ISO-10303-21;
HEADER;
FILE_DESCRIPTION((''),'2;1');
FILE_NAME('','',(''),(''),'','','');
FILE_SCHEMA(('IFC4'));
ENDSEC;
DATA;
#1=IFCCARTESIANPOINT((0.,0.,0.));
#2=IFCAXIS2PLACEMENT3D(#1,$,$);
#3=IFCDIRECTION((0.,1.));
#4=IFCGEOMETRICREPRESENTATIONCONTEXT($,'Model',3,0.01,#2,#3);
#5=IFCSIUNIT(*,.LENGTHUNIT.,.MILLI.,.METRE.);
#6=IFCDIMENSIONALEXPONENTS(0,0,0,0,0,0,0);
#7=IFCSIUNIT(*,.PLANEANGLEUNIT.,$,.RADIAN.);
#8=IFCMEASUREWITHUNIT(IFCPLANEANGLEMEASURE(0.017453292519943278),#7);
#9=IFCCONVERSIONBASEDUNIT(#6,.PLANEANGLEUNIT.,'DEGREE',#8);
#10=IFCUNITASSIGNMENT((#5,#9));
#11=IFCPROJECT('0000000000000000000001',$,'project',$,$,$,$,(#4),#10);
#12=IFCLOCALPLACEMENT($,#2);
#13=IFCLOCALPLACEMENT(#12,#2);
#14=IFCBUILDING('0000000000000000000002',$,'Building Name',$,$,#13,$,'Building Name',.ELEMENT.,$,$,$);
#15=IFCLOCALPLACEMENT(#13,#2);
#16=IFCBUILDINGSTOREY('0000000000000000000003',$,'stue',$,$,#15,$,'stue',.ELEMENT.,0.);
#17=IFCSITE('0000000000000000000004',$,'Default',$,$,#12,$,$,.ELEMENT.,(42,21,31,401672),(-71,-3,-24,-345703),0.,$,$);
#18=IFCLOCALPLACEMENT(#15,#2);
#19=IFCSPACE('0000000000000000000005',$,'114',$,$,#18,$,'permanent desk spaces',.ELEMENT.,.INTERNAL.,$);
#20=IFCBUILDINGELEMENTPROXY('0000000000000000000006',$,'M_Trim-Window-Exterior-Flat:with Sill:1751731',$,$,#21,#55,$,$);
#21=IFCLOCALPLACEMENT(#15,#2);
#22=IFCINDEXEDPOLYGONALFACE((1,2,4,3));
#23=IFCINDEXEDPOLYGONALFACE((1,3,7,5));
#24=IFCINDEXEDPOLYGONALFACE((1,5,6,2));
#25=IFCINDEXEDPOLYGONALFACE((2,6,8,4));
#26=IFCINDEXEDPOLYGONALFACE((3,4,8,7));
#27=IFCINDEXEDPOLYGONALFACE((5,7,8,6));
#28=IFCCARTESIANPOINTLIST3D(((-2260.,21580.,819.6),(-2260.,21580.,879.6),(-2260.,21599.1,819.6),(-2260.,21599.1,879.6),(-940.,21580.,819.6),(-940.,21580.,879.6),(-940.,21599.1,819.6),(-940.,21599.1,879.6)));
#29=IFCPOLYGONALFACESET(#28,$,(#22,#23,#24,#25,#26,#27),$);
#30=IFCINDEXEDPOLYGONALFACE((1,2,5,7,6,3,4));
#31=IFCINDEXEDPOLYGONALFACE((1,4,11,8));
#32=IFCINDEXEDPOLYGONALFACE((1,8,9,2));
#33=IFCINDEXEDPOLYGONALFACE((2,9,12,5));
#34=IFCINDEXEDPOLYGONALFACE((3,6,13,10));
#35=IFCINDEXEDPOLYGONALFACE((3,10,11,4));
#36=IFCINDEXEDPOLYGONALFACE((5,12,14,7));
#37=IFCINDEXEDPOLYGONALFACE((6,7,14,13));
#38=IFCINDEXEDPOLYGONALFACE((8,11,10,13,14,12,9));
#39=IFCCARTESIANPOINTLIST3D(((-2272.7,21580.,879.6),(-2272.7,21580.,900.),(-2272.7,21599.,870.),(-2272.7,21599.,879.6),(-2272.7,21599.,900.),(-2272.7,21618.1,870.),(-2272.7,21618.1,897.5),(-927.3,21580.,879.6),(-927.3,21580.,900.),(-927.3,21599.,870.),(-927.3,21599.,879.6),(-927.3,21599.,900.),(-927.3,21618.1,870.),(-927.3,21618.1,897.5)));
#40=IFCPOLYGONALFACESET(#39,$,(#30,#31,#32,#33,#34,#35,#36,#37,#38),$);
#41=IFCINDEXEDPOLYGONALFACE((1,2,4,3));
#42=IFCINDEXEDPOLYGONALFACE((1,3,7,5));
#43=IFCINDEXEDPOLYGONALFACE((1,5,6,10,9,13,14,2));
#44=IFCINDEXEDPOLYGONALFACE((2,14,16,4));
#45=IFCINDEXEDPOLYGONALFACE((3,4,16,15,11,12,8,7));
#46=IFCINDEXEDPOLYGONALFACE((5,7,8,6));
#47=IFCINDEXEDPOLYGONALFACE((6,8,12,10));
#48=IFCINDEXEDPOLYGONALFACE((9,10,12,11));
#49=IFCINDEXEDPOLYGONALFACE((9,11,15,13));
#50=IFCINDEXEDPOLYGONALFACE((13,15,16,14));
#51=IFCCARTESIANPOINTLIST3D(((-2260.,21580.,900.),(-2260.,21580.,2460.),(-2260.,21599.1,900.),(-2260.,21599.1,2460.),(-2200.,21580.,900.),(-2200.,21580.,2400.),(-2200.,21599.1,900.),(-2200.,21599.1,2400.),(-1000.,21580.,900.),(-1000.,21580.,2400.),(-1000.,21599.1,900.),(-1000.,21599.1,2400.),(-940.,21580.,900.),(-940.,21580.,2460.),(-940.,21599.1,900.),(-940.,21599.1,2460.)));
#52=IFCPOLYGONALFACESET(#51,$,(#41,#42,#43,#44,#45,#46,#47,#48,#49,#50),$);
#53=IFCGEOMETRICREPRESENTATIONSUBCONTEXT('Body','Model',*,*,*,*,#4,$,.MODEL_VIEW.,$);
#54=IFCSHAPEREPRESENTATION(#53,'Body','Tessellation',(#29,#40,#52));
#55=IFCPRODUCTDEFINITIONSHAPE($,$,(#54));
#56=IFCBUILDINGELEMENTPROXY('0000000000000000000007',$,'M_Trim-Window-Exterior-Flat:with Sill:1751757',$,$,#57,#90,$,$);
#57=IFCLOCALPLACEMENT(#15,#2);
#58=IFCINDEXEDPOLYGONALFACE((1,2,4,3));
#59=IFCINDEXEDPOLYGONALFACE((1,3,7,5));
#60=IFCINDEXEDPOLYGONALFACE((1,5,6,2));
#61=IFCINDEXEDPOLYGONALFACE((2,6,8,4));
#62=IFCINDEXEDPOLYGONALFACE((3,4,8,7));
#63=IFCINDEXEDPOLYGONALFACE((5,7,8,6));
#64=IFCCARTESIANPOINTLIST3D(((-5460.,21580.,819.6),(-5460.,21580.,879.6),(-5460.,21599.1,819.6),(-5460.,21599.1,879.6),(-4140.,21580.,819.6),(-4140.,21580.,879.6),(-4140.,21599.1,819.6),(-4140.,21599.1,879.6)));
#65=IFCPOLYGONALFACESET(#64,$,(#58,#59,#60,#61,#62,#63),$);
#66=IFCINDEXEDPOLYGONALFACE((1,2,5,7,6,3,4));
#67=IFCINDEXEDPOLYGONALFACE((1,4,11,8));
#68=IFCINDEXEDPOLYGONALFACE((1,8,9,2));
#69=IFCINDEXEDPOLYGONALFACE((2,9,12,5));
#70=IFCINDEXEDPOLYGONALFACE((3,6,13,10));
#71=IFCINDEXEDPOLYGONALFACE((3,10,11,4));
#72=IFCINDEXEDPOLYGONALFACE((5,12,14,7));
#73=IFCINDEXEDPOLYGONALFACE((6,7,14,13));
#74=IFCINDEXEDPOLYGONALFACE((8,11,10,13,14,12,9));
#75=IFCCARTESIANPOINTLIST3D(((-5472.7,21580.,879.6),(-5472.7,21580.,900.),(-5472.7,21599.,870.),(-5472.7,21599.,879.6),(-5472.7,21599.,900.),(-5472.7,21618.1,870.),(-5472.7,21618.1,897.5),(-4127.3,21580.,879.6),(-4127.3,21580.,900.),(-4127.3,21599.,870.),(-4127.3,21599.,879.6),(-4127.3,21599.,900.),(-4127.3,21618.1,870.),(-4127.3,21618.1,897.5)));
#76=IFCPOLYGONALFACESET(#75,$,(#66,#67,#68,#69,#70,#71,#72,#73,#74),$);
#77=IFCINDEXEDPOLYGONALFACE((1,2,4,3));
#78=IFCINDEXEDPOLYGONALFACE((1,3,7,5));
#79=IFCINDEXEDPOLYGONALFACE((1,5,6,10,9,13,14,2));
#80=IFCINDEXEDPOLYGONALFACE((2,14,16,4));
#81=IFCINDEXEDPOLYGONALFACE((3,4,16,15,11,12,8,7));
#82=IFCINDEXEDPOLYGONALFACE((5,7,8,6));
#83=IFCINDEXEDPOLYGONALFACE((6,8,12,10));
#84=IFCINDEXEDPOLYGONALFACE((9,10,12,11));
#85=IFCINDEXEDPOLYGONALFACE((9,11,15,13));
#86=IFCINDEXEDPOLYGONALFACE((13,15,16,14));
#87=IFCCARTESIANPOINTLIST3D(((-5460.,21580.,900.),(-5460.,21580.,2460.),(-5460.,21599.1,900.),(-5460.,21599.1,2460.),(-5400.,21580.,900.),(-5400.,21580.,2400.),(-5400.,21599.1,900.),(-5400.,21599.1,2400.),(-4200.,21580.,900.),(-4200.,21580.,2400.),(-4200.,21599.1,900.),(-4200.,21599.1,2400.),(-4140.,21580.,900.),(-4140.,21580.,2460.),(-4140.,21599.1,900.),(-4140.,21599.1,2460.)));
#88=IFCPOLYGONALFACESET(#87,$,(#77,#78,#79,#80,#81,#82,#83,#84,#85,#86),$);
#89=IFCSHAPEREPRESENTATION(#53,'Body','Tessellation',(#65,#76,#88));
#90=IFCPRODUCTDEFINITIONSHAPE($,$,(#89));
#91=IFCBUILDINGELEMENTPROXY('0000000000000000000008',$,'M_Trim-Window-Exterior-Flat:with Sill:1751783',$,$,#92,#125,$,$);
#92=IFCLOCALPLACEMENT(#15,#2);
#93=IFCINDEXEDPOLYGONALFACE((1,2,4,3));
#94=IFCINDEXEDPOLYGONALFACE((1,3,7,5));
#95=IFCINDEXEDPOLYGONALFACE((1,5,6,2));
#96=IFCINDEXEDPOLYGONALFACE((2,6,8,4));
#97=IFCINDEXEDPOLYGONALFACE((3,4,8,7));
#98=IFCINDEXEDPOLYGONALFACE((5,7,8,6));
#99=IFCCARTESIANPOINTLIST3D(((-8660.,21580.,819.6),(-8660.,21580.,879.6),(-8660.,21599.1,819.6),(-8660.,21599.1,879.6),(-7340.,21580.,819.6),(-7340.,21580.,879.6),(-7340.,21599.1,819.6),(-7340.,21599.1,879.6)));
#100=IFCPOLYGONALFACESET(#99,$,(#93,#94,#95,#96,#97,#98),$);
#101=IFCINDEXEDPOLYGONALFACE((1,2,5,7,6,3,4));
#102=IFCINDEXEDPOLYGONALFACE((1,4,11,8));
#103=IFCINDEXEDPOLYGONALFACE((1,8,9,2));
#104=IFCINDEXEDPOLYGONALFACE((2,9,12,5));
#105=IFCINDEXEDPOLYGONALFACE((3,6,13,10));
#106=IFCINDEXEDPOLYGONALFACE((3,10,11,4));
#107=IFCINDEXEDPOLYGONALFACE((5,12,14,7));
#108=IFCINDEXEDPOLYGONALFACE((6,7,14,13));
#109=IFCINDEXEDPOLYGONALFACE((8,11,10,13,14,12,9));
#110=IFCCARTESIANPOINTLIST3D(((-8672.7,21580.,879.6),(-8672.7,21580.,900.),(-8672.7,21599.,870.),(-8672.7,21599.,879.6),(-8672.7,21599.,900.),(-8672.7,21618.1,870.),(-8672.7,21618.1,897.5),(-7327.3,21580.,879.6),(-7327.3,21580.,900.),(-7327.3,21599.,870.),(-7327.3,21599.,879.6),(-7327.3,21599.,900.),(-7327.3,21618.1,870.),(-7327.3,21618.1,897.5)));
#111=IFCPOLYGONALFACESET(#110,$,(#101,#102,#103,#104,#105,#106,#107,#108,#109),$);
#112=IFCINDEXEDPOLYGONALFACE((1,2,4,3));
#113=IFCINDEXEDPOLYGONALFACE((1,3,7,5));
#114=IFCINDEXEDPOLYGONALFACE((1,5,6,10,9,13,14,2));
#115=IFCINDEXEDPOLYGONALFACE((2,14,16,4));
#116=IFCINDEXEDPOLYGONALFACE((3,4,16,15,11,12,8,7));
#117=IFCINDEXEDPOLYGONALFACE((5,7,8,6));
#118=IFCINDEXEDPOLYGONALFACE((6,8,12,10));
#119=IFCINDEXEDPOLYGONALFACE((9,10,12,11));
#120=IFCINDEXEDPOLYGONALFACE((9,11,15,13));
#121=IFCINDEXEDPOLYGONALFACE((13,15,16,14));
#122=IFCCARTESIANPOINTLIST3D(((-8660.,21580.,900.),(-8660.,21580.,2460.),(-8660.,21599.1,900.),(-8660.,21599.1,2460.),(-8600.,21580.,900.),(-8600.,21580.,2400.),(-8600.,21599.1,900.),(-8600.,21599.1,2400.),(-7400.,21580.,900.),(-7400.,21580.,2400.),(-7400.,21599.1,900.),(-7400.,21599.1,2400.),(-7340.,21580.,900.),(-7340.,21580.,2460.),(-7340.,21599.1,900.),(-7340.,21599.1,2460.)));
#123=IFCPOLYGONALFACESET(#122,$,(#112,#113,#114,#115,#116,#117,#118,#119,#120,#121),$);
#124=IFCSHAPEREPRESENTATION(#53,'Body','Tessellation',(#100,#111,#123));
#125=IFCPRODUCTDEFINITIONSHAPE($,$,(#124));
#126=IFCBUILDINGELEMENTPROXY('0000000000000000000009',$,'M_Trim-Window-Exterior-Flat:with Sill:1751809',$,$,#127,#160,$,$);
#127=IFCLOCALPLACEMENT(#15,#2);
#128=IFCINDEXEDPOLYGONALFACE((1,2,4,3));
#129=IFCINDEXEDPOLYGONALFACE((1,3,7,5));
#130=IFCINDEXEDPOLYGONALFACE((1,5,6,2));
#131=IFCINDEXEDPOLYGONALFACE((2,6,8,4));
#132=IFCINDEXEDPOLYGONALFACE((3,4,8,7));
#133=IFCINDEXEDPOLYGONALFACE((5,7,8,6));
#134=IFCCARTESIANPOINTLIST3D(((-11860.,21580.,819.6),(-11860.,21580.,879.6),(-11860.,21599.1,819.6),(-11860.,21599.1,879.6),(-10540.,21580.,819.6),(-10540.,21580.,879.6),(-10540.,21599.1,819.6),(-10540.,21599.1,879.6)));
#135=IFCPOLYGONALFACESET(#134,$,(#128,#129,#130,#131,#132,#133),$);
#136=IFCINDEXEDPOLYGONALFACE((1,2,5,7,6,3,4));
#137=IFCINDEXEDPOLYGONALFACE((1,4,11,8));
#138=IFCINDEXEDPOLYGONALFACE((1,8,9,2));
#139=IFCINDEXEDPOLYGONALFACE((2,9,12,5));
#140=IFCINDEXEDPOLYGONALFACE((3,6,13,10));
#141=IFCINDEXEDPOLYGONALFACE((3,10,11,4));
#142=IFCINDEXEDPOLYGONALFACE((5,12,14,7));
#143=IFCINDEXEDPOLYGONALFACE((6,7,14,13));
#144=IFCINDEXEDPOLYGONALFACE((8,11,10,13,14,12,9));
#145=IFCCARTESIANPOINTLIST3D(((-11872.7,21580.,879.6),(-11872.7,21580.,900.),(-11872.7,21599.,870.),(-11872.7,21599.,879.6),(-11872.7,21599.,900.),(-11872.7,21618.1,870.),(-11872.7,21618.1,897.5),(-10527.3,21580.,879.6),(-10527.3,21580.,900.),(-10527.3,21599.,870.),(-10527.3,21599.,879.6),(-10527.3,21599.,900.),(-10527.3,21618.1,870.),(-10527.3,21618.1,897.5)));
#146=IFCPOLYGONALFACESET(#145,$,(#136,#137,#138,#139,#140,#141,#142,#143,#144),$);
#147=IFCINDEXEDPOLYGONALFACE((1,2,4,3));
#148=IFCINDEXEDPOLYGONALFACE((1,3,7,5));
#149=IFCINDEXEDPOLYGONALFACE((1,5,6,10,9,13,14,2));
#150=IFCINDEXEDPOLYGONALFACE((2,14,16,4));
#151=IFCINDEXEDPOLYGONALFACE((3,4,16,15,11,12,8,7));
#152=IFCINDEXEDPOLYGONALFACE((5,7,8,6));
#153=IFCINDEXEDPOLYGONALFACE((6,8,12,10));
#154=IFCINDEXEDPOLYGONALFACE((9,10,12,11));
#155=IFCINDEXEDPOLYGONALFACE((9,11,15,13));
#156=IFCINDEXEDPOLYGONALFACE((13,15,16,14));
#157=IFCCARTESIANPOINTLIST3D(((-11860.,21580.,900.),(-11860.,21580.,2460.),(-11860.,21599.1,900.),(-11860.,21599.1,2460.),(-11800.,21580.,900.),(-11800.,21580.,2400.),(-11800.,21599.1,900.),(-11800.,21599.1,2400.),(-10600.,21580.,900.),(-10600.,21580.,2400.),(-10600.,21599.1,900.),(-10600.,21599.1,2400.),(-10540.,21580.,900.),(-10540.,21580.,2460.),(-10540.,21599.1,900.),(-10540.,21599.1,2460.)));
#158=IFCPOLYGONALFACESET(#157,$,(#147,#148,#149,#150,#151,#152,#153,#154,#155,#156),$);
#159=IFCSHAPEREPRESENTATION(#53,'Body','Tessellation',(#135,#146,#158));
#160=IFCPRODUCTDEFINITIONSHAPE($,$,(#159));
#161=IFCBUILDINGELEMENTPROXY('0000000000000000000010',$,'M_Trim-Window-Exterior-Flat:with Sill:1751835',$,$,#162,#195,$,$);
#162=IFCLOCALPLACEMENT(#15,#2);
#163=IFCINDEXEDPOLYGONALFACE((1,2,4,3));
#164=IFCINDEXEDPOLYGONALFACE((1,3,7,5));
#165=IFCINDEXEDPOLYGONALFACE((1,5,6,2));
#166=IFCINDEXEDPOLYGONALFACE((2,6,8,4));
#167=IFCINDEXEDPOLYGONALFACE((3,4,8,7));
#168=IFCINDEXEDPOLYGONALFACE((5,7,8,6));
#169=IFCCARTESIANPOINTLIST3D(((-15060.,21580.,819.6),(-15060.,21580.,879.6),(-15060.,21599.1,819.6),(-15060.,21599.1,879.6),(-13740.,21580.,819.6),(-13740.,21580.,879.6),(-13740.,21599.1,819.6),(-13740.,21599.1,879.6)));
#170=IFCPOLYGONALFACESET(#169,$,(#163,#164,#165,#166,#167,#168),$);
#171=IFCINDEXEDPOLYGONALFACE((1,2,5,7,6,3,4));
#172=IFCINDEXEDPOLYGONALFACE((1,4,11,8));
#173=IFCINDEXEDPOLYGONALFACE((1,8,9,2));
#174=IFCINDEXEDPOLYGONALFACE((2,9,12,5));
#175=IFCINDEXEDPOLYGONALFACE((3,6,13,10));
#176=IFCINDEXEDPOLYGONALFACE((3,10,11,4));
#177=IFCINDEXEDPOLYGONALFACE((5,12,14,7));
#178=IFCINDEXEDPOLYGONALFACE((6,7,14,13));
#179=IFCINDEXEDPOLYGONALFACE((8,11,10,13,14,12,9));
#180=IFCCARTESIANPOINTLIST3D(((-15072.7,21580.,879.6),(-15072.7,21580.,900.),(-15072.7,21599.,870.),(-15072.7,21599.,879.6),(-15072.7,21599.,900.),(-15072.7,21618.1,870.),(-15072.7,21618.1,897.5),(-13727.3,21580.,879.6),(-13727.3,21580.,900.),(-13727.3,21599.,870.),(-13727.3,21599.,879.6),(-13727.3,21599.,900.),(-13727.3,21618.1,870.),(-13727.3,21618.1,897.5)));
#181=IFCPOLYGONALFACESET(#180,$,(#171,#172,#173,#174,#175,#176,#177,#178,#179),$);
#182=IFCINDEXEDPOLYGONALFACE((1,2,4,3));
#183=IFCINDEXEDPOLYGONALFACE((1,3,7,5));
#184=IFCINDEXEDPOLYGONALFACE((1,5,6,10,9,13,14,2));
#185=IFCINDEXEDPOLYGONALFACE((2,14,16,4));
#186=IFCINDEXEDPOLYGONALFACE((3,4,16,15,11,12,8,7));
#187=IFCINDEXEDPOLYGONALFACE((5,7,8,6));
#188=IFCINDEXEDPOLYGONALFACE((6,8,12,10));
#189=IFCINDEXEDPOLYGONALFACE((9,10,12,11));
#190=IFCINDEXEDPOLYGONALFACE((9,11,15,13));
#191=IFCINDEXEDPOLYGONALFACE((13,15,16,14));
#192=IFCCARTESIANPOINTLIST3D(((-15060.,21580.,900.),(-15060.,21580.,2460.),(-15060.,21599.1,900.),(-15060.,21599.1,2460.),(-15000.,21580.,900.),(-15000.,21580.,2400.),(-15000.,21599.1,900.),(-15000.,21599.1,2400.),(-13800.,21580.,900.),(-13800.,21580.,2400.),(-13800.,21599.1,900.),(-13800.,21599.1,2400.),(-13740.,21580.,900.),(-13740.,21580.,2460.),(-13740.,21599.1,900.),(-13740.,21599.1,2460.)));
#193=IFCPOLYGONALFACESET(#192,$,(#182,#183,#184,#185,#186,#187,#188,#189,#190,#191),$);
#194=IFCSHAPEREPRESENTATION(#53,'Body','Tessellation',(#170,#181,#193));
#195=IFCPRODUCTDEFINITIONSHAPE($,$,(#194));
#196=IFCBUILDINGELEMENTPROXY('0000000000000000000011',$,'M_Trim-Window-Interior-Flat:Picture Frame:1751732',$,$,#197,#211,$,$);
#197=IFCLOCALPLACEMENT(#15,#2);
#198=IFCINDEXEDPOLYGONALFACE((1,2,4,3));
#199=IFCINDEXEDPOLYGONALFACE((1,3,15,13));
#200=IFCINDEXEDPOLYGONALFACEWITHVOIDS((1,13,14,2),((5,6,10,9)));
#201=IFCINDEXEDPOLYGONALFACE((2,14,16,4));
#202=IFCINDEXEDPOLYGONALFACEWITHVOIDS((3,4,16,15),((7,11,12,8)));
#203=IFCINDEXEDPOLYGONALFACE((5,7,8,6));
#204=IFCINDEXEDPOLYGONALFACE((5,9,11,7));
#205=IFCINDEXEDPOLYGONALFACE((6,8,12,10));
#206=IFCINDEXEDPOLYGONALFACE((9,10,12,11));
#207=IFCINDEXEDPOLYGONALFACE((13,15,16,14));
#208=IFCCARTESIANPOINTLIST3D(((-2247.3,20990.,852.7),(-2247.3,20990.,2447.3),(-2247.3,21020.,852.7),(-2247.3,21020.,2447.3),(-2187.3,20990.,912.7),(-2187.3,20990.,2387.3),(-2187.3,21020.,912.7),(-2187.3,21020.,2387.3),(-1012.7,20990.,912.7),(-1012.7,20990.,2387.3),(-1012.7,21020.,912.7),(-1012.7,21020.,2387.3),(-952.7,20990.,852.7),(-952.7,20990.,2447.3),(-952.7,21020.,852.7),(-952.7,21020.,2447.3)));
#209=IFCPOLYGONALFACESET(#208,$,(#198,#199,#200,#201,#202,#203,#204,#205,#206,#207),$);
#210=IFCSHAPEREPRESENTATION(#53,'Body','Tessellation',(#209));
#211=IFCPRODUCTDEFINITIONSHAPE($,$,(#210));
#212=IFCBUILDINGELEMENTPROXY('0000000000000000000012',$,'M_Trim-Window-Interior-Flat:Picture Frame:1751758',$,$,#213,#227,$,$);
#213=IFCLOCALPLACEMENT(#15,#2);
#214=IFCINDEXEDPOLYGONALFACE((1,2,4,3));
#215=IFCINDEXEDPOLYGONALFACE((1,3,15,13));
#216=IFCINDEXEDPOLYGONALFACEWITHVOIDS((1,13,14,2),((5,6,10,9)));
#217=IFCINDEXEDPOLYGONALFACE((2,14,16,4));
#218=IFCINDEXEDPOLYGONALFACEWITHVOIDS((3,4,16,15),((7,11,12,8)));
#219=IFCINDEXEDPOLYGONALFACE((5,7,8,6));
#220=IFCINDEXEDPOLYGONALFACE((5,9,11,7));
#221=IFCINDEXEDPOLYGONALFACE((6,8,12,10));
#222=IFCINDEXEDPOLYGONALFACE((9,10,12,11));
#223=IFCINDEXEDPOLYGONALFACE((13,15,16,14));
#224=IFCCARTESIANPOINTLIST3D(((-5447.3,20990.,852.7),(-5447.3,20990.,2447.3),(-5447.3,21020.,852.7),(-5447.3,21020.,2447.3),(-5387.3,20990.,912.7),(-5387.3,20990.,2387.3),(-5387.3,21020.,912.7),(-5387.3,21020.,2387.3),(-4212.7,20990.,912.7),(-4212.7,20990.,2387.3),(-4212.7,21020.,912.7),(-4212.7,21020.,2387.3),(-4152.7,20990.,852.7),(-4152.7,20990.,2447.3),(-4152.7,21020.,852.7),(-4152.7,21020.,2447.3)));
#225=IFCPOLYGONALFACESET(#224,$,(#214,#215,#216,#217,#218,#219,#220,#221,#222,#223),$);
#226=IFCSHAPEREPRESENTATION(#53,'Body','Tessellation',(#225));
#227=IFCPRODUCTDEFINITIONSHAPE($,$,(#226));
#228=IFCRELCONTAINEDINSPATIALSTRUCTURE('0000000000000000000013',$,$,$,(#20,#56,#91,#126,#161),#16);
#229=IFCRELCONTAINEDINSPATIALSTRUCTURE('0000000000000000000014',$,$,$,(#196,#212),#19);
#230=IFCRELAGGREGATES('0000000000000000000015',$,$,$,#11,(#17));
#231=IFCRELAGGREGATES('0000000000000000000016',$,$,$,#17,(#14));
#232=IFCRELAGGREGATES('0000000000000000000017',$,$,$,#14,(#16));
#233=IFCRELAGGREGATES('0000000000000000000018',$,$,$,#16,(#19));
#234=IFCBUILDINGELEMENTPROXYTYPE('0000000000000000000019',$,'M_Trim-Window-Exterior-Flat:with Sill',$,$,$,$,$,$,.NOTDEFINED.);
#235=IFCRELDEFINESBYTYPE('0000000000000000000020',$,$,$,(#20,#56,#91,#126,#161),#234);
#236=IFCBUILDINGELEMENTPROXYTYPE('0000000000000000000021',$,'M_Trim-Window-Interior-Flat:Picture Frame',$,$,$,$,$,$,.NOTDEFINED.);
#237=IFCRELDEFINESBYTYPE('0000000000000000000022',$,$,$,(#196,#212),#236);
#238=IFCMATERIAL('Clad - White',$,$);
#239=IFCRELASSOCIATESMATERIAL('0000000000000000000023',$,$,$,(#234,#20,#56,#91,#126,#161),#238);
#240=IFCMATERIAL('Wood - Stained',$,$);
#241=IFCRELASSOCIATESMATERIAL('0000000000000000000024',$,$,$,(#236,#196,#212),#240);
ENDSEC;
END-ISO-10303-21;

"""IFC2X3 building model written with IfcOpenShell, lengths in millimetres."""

from ifc_helpers import new_model, entity, si_unit, converted_unit, direction, frame, frame_2d, origin, place, context, subcontext, project, spatial, polyline, rectangle, outline, extrude, source, transform, mapped, material, type_object, type_shapes, element, save


model = new_model("IFC2X3")

# Units and contexts
model_context = context("Model", 3, precision=0.01, world=origin(), true_north=direction((0.0, 1.0)))
body_context = subcontext(model_context, "Body", "Model", "MODEL_VIEW")
ifc_project = project(units=[si_unit("LENGTHUNIT", "METRE", prefix="MILLI"), converted_unit("PLANEANGLEUNIT", "DEGREE", entity("IfcPlaneAngleMeasure", 0.017453292519943278), si_unit("PLANEANGLEUNIT", "RADIAN"), dimensions=[0, 0, 0, 0, 0, 0, 0])], contexts=[model_context])

# Site, building, storey
site_placement = place(None, origin())
site = spatial("IfcSite", under=ifc_project, at=site_placement, Name="Default", CompositionType="ELEMENT", RefLatitude=(42, 21, 31, 401672), RefLongitude=(-71, -3, -24, -345703), RefElevation=0.0)
building_placement = place(site_placement, origin())
building = spatial("IfcBuilding", under=site, at=building_placement, Name="Building Name", LongName="Building Name", CompositionType="ELEMENT")
storey_placement = place(building_placement, origin())
storey = spatial("IfcBuildingStorey", under=building, at=storey_placement, Name="stue", LongName="stue", CompositionType="ELEMENT", Elevation=0.0)

# Building element proxies
ifc_material_1 = material(Name="Clad - White")
ifc_material_2 = material(Name="Wood - Stained")
building_element_proxy_type_1 = type_object("IfcBuildingElementProxyType", Name="M_Trim-Window-Exterior-Flat:with Sill", PredefinedType="NOTDEFINED", material=ifc_material_1)
shared_shape_1 = source(origin(), body_context, "Body", "SweptSolid", [
    extrude(rectangle(XDim=1320.0, YDim=60.0, at=frame_2d((0.0, 0.0), x_axis=(1.0, 0.0))), frame((0.0, -1550.4, 0.0), z_axis=(0.0, 0.0, 1.0), x_axis=(-1.0, 0.0, 0.0)), (0.0, 0.0, 1.0), 19.0),
    extrude(outline(polyline([(-19.0, -15.2), (0.0, -15.2), (0.0, -5.7), (19.0, -5.7), (19.0, 14.8), (0.0, 14.8), (-19.0, 12.3), (-19.0, -15.2)])), frame((-672.7, -1514.8, 19.0), z_axis=(1.0, 0.0, 0.0), x_axis=(0.0, 0.0, -1.0)), (0.0, 0.0, 1.0), 1345.4),
    extrude(outline(polyline([(-795.0, -660.0), (765.0, -660.0), (765.0, -600.0), (-735.0, -600.0), (-735.0, 600.0), (765.0, 600.0), (765.0, 660.0), (-795.0, 660.0), (-795.0, -660.0)])), frame((0.0, -735.0, 0.0), z_axis=(0.0, 0.0, 1.0), x_axis=(0.0, -1.0, 0.0)), (0.0, 0.0, 1.0), 19.0),
])
type_shapes(building_element_proxy_type_1, [shared_shape_1])
for number, where, z_axis, x_axis, name in (
    (1, (-1600.0, 21580.0, 2400.0), (0.0, 1.0, 0.0), (-1.0, 0.0, 0.0), "M_Trim-Window-Exterior-Flat:with Sill:1751731"),
    (2, (-4800.0, 21580.0, 2400.0), (0.0, 1.0, 0.0), (-1.0, 0.0, 0.0), "M_Trim-Window-Exterior-Flat:with Sill:1751757"),
    (3, (-8000.0, 21580.0, 2400.0), (0.0, 1.0, 0.0), (-1.0, 0.0, 0.0), "M_Trim-Window-Exterior-Flat:with Sill:1751783"),
    (4, (-11200.0, 21580.0, 2400.0), (0.0, 1.0, 0.0), (-1.0, 0.0, 0.0), "M_Trim-Window-Exterior-Flat:with Sill:1751809"),
    (5, (-14400.0, 21580.0, 2400.0), (0.0, 1.0, 0.0), (-1.0, 0.0, 0.0), "M_Trim-Window-Exterior-Flat:with Sill:1751835"),
):
    element("IfcBuildingElementProxy", number, at=place(storey_placement, frame(where, z_axis=z_axis, x_axis=x_axis)), inside=storey, type_object=building_element_proxy_type_1, material=ifc_material_1, Name=name, context=body_context, shape_type="MappedRepresentation", body=[
        mapped(shared_shape_1, transform((0.0, 0.0, 0.0), scale=1.0)),
    ])

# Shared definitions
space_1_placement = place(storey_placement, origin())
space_1 = spatial("IfcSpace", under=storey, at=space_1_placement, Name="114", LongName="permanent desk spaces", CompositionType="ELEMENT", InteriorOrExteriorSpace="INTERNAL")

# Building element proxies
building_element_proxy_type_2 = type_object("IfcBuildingElementProxyType", Name="M_Trim-Window-Interior-Flat:Picture Frame", PredefinedType="NOTDEFINED", material=ifc_material_2)
shared_shape_2 = source(origin(), body_context, "Body", "SweptSolid", [
    extrude(outline(polyline([(-647.3, -797.3), (647.3, -797.3), (647.3, 797.3), (-647.3, 797.3), (-647.3, -797.3)]), holes=[polyline([(-587.3, -737.3), (-587.3, 737.3), (587.3, 737.3), (587.3, -737.3), (-587.3, -737.3)])]), frame((0.0, -750.0, 0.0), z_axis=(0.0, 0.0, 1.0), x_axis=(-1.0, 0.0, 0.0)), (0.0, 0.0, 1.0), 30.0),
])
type_shapes(building_element_proxy_type_2, [shared_shape_2])
for number, where, z_axis, x_axis, name in (
    (6, (-1600.0, 21020.0, 2400.0), (0.0, -1.0, 0.0), (1.0, 0.0, 0.0), "M_Trim-Window-Interior-Flat:Picture Frame:1751732"),
    (7, (-4800.0, 21020.0, 2400.0), (0.0, -1.0, 0.0), (1.0, 0.0, 0.0), "M_Trim-Window-Interior-Flat:Picture Frame:1751758"),
):
    element("IfcBuildingElementProxy", number, at=place(space_1_placement, frame(where, z_axis=z_axis, x_axis=x_axis)), inside=space_1, type_object=building_element_proxy_type_2, material=ifc_material_2, Name=name, context=body_context, shape_type="MappedRepresentation", body=[
        mapped(shared_shape_2, transform((0.0, 0.0, 0.0), scale=1.0)),
    ])

save(model, "model.ifc")
